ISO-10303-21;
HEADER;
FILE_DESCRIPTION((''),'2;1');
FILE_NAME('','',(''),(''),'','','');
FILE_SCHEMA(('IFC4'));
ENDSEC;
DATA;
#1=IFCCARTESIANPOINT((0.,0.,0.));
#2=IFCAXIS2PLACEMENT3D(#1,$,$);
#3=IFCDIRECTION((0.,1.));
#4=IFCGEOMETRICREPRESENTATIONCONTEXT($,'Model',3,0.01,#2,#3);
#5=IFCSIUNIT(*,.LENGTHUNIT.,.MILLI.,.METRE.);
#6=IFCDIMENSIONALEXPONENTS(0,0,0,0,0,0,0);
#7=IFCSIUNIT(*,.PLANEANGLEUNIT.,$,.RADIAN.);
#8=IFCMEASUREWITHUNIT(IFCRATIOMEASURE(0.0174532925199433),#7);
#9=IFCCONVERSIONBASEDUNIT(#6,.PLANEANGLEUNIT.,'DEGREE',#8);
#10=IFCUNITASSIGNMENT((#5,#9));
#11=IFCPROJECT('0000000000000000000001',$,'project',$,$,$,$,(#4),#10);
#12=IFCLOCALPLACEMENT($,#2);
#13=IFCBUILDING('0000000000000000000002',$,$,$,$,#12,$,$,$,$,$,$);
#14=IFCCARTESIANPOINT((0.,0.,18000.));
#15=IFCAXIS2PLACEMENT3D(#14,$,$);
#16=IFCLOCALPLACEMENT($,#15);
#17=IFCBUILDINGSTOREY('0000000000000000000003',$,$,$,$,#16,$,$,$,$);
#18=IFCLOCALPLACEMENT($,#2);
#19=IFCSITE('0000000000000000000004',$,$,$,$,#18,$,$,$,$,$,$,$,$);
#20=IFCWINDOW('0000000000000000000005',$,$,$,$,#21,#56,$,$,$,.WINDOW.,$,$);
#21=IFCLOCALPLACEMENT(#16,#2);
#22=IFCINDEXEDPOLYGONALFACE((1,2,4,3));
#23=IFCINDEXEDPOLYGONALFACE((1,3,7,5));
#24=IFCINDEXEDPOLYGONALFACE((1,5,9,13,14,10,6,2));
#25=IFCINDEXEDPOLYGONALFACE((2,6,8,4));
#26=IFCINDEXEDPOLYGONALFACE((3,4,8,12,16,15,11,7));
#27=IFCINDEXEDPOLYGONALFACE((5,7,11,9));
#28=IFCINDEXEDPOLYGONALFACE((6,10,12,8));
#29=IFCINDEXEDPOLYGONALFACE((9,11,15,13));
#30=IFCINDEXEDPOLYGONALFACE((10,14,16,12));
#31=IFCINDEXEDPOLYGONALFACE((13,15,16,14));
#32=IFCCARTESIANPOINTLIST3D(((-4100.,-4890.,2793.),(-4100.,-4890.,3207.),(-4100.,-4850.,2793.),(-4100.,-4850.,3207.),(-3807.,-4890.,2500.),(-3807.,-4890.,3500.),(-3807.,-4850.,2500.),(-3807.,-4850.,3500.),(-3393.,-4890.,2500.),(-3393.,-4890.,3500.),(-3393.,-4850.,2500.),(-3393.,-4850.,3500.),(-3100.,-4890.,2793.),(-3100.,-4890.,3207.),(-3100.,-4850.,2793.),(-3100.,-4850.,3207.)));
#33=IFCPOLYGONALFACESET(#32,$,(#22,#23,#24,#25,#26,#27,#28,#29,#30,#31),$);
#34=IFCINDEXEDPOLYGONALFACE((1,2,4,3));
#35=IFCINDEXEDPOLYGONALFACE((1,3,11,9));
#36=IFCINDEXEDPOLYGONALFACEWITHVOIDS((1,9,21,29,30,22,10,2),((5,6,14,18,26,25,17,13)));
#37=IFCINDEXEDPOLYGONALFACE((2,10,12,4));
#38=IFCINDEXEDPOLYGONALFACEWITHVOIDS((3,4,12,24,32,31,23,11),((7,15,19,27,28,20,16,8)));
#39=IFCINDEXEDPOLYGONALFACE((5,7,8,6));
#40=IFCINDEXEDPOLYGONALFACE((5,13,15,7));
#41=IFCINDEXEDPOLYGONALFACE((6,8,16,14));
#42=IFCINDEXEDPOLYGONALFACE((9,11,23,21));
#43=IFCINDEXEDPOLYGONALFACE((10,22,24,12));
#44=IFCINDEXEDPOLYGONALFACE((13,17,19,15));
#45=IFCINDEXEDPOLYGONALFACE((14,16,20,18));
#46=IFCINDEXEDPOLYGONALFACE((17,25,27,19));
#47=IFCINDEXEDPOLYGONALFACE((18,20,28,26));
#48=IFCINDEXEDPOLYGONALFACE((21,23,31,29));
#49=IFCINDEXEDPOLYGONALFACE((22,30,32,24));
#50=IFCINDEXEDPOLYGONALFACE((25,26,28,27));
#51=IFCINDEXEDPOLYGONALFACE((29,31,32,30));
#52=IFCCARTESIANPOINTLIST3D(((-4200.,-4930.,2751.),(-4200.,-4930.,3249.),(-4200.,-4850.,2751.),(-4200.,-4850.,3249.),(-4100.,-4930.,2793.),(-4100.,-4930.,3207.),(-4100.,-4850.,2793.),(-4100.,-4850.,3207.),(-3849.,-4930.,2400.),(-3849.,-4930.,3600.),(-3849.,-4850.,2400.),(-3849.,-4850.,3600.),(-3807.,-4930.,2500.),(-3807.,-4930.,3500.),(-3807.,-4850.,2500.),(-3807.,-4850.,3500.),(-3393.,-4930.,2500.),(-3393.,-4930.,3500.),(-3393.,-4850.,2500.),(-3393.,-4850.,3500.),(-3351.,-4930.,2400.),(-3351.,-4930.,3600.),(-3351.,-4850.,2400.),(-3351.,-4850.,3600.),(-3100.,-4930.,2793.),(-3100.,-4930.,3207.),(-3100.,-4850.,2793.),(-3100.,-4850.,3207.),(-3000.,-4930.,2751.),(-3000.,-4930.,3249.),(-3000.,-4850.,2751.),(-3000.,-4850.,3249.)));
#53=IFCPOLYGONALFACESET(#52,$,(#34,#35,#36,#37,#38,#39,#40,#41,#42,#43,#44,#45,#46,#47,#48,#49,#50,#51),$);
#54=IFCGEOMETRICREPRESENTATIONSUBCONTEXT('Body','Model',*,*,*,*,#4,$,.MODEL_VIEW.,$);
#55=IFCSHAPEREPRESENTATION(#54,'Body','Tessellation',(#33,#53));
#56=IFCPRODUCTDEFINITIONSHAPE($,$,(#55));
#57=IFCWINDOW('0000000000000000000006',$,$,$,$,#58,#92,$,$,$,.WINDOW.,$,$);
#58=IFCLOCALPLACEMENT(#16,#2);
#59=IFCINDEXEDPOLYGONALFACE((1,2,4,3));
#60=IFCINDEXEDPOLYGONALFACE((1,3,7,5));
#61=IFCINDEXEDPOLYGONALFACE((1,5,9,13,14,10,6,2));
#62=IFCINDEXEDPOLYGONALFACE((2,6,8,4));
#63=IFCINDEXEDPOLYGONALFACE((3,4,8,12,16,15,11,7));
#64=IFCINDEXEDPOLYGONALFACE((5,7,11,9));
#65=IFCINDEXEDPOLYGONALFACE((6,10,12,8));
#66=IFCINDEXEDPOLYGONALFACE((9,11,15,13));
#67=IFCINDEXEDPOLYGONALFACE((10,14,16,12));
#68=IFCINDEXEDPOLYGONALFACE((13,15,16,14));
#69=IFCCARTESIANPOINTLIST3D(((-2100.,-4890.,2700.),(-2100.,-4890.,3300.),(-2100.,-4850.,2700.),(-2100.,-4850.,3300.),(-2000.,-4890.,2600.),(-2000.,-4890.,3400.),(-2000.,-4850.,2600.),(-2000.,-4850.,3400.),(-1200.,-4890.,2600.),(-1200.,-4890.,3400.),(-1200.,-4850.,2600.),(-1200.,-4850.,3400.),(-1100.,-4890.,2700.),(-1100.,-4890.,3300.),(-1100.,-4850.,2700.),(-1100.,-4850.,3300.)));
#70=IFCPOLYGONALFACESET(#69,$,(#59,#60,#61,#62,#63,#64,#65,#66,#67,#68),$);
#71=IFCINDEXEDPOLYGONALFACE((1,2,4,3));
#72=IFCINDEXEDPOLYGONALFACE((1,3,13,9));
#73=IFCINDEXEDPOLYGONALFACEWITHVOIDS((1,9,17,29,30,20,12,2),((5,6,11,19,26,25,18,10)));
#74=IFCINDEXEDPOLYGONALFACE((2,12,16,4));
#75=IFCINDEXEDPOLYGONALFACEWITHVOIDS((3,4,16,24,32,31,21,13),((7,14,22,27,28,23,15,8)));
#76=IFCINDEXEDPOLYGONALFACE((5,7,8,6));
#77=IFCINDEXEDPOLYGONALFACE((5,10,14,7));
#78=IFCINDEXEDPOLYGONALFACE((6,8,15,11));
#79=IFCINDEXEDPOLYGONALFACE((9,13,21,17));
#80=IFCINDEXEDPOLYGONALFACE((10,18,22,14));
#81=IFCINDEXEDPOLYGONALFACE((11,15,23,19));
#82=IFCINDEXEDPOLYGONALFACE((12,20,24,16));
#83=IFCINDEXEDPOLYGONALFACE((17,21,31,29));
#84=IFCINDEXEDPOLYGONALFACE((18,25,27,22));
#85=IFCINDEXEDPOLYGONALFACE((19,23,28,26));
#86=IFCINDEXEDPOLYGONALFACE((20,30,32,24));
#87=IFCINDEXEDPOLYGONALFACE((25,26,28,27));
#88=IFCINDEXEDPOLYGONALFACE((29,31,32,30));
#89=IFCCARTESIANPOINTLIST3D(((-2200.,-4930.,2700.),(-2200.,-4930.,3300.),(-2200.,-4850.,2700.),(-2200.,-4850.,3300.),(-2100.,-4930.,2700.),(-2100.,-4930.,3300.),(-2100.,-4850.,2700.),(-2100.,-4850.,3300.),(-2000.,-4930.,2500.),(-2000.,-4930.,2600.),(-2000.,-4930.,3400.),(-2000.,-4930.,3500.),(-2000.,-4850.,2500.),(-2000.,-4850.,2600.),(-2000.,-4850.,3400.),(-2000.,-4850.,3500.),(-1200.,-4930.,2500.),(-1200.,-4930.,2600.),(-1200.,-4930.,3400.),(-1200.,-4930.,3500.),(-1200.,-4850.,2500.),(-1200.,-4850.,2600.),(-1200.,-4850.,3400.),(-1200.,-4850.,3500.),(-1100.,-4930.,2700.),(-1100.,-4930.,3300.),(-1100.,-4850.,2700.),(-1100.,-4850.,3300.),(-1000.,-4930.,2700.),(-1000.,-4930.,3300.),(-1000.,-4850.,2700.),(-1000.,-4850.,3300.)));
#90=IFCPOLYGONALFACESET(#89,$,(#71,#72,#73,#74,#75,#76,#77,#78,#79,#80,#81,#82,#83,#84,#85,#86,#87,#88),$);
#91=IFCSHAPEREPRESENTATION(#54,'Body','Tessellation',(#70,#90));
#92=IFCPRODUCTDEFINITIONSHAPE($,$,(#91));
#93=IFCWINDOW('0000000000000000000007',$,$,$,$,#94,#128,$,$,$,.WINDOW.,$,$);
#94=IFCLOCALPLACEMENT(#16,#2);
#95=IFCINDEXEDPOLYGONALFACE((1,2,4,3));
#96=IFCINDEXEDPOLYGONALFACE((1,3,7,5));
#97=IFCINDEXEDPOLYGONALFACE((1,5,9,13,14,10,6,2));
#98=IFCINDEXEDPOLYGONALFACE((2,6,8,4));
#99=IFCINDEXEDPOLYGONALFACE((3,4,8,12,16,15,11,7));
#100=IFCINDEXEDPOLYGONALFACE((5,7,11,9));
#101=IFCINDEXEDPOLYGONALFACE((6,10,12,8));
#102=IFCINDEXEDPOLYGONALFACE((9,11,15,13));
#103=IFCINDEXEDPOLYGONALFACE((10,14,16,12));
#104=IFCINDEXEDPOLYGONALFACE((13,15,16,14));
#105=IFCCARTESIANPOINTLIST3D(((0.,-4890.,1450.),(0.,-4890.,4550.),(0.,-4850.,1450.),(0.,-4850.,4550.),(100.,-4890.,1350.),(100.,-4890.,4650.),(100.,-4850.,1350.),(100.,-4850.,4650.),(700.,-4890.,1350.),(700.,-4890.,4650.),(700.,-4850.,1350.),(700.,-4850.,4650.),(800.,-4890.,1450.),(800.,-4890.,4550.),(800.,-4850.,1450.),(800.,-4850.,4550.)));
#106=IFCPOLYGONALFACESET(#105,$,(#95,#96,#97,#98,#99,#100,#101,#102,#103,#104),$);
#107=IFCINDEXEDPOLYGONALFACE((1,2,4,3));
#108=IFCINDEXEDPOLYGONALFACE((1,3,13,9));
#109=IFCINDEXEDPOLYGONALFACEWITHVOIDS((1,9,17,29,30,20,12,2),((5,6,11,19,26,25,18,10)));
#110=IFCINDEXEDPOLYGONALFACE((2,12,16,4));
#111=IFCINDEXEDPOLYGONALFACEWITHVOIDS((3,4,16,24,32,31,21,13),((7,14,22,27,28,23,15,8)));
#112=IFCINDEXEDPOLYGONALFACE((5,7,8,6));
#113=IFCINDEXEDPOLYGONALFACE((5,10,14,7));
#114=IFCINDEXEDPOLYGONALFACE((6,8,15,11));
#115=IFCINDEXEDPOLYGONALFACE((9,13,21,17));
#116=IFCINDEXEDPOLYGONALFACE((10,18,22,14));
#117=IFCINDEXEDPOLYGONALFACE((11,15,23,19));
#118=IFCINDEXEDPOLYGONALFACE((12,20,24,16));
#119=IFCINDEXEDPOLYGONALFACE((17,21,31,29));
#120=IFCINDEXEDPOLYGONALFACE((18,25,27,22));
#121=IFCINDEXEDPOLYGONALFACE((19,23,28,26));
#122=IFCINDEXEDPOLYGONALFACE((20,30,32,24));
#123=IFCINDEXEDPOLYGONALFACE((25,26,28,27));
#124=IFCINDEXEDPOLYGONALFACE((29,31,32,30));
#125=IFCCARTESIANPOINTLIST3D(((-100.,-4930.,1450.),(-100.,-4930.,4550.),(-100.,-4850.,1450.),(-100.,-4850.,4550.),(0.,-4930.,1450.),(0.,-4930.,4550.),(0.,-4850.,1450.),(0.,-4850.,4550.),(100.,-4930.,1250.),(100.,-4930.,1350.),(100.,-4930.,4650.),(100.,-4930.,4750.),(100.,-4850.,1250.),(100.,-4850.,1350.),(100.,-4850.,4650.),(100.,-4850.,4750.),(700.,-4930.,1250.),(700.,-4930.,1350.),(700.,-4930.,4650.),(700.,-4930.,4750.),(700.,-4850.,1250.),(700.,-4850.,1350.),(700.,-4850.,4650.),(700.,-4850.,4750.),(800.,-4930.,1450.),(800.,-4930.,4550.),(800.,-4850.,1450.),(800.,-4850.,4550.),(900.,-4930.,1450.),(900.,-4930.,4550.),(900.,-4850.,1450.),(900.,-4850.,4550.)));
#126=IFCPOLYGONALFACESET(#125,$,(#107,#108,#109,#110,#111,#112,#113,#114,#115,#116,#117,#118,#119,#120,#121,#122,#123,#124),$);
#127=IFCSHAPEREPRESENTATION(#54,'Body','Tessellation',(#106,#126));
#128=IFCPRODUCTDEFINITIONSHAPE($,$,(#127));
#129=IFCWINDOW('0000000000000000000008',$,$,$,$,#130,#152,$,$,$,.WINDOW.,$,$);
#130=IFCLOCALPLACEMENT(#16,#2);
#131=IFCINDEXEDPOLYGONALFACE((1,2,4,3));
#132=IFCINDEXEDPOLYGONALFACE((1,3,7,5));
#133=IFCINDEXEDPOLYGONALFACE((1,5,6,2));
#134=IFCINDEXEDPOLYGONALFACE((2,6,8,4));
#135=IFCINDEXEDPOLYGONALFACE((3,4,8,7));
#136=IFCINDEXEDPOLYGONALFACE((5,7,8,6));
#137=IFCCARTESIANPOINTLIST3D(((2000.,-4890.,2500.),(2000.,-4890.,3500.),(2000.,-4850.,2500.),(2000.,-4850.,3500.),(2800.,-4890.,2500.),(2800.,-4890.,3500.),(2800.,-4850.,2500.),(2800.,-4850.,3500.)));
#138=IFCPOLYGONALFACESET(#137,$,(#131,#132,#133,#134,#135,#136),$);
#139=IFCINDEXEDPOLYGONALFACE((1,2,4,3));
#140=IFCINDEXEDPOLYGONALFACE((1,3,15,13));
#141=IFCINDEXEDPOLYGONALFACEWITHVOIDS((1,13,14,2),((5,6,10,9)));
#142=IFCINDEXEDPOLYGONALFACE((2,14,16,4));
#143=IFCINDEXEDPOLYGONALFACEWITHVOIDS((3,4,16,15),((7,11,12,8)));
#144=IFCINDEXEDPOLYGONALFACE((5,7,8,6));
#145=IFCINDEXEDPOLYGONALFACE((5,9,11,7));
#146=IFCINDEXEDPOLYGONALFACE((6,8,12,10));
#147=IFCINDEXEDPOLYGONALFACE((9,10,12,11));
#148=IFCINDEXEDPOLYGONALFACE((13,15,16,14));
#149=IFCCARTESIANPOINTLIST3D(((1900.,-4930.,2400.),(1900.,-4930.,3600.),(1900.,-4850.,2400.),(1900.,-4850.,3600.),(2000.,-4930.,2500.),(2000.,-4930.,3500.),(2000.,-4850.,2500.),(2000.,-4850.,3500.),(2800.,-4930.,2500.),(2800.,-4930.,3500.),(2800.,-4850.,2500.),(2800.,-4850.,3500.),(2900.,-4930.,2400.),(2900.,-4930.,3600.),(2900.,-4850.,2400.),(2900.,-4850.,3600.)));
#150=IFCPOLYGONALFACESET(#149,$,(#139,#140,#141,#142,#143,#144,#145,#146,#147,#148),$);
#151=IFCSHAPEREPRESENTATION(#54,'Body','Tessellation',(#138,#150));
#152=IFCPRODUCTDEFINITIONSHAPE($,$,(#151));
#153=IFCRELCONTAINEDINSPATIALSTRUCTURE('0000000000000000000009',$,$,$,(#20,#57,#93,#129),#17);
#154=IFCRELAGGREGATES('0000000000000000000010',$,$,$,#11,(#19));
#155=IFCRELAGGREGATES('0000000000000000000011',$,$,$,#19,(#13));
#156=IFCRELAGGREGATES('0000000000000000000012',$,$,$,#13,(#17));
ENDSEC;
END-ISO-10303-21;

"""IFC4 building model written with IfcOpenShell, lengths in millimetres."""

from ifc_helpers import new_model, entity, si_unit, converted_unit, direction, frame, origin, place, context, subcontext, project, spatial, element, save


model = new_model("IFC4")

# Units and contexts
model_context = context("Model", 3, precision=0.01, world=origin(), true_north=direction((0.0, 1.0)))
body_context = subcontext(model_context, "Body", "Model", "MODEL_VIEW")
ifc_project = project(units=[si_unit("LENGTHUNIT", "METRE", prefix="MILLI"), converted_unit("PLANEANGLEUNIT", "DEGREE", entity("IfcRatioMeasure", 0.0174532925199433), si_unit("PLANEANGLEUNIT", "RADIAN"), dimensions=[0, 0, 0, 0, 0, 0, 0])], contexts=[model_context])

# Site, building, storey
site_placement = place(None, origin())
site = spatial("IfcSite", under=ifc_project, at=site_placement)
building_placement = place(None, origin())
building = spatial("IfcBuilding", under=site, at=building_placement)
storey_placement = place(None, frame((0.0, 0.0, 18000.0)))
storey = spatial("IfcBuildingStorey", under=building, at=storey_placement)

# Shared definitions
cartesian_point_1 = entity("IfcCartesianPoint", [-500.0, -207.0])
shared_polyline_1 = entity("IfcPolyline", [cartesian_point_1, entity("IfcCartesianPoint", [-500.0, 207.0]), entity("IfcCartesianPoint", [-207.0, 500.0]), entity("IfcCartesianPoint", [207.0, 500.0]), entity("IfcCartesianPoint", [500.0, 207.0]), entity("IfcCartesianPoint", [500.0, -207.0]), entity("IfcCartesianPoint", [207.0, -500.0]), entity("IfcCartesianPoint", [-207.0, -500.0]), cartesian_point_1])
cartesian_point_2 = entity("IfcCartesianPoint", [-500.0, -300.0])
shared_polyline_2 = entity("IfcPolyline", [cartesian_point_2, entity("IfcCartesianPoint", [-500.0, 300.0]), entity("IfcCartesianPoint", [-400.0, 400.0]), entity("IfcCartesianPoint", [400.0, 400.0]), entity("IfcCartesianPoint", [500.0, 300.0]), entity("IfcCartesianPoint", [500.0, -300.0]), entity("IfcCartesianPoint", [400.0, -400.0]), entity("IfcCartesianPoint", [-400.0, -400.0]), cartesian_point_2])
cartesian_point_3 = entity("IfcCartesianPoint", [-400.0, -1550.0])
shared_polyline_3 = entity("IfcPolyline", [cartesian_point_3, entity("IfcCartesianPoint", [-400.0, 1550.0]), entity("IfcCartesianPoint", [-300.0, 1650.0]), entity("IfcCartesianPoint", [300.0, 1650.0]), entity("IfcCartesianPoint", [400.0, 1550.0]), entity("IfcCartesianPoint", [400.0, -1550.0]), entity("IfcCartesianPoint", [300.0, -1650.0]), entity("IfcCartesianPoint", [-300.0, -1650.0]), cartesian_point_3])
cartesian_point_4 = entity("IfcCartesianPoint", [-400.0, -500.0])
shared_polyline_4 = entity("IfcPolyline", [cartesian_point_4, entity("IfcCartesianPoint", [-400.0, 500.0]), entity("IfcCartesianPoint", [-400.0, 500.0]), entity("IfcCartesianPoint", [400.0, 500.0]), entity("IfcCartesianPoint", [400.0, 500.0]), entity("IfcCartesianPoint", [400.0, -500.0]), entity("IfcCartesianPoint", [400.0, -500.0]), entity("IfcCartesianPoint", [-400.0, -500.0]), cartesian_point_4])

# Shared definitions
wall_1_placement = place(storey_placement, frame((-100.0, -4900.0, 0.0), z_axis=(0.0, 0.0, 1.0), x_axis=(1.0, 0.0, 0.0)))
window_1_placement = place(wall_1_placement, frame((-3500.0, 50.0, 3000.0)))
window_2_placement = place(wall_1_placement, frame((-1500.0, 50.0, 3000.0)))
window_3_placement = place(wall_1_placement, frame((500.0, 50.0, 3000.0)))
window_4_placement = place(wall_1_placement, frame((2500.0, 50.0, 3000.0)))

# Windows
cartesian_point_5 = entity("IfcCartesianPoint", [-600.0, -249.0])
element("IfcWindow", 1, at=window_1_placement, inside=storey, PredefinedType="WINDOW", context=body_context, shape_type="SweptSolid", body=[
    entity("IfcExtrudedAreaSolid", entity("IfcArbitraryClosedProfileDef", "AREA", None, shared_polyline_1), entity("IfcAxis2Placement3D", entity("IfcCartesianPoint", [0.0, 0.0, 0.0]), entity("IfcDirection", [0.0, -1.0, 0.0]), entity("IfcDirection", [1.0, 0.0, 0.0])), entity("IfcDirection", [0.0, 0.0, 1.0]), 40.0),
    entity("IfcExtrudedAreaSolid", entity("IfcArbitraryProfileDefWithVoids", "AREA", None, entity("IfcPolyline", [cartesian_point_5, entity("IfcCartesianPoint", [-600.0, 249.0]), entity("IfcCartesianPoint", [-249.0, 600.0]), entity("IfcCartesianPoint", [249.0, 600.0]), entity("IfcCartesianPoint", [600.0, 249.0]), entity("IfcCartesianPoint", [600.0, -249.0]), entity("IfcCartesianPoint", [249.0, -600.0]), entity("IfcCartesianPoint", [-249.0, -600.0]), cartesian_point_5]), [shared_polyline_1]), entity("IfcAxis2Placement3D", entity("IfcCartesianPoint", [0.0, 0.0, 0.0]), entity("IfcDirection", [0.0, -1.0, 0.0]), entity("IfcDirection", [1.0, 0.0, 0.0])), entity("IfcDirection", [0.0, 0.0, 1.0]), 80.0),
])
cartesian_point_6 = entity("IfcCartesianPoint", [-600.0, -300.0])
element("IfcWindow", 2, at=window_2_placement, inside=storey, PredefinedType="WINDOW", context=body_context, shape_type="SweptSolid", body=[
    entity("IfcExtrudedAreaSolid", entity("IfcArbitraryClosedProfileDef", "AREA", None, shared_polyline_2), entity("IfcAxis2Placement3D", entity("IfcCartesianPoint", [0.0, 0.0, 0.0]), entity("IfcDirection", [0.0, -1.0, 0.0]), entity("IfcDirection", [1.0, 0.0, 0.0])), entity("IfcDirection", [0.0, 0.0, 1.0]), 40.0),
    entity("IfcExtrudedAreaSolid", entity("IfcArbitraryProfileDefWithVoids", "AREA", None, entity("IfcPolyline", [cartesian_point_6, entity("IfcCartesianPoint", [-600.0, 300.0]), entity("IfcCartesianPoint", [-400.0, 500.0]), entity("IfcCartesianPoint", [400.0, 500.0]), entity("IfcCartesianPoint", [600.0, 300.0]), entity("IfcCartesianPoint", [600.0, -300.0]), entity("IfcCartesianPoint", [400.0, -500.0]), entity("IfcCartesianPoint", [-400.0, -500.0]), cartesian_point_6]), [shared_polyline_2]), entity("IfcAxis2Placement3D", entity("IfcCartesianPoint", [0.0, 0.0, 0.0]), entity("IfcDirection", [0.0, -1.0, 0.0]), entity("IfcDirection", [1.0, 0.0, 0.0])), entity("IfcDirection", [0.0, 0.0, 1.0]), 80.0),
])
cartesian_point_7 = entity("IfcCartesianPoint", [-500.0, -1550.0])
element("IfcWindow", 3, at=window_3_placement, inside=storey, PredefinedType="WINDOW", context=body_context, shape_type="SweptSolid", body=[
    entity("IfcExtrudedAreaSolid", entity("IfcArbitraryClosedProfileDef", "AREA", None, shared_polyline_3), entity("IfcAxis2Placement3D", entity("IfcCartesianPoint", [0.0, 0.0, 0.0]), entity("IfcDirection", [0.0, -1.0, 0.0]), entity("IfcDirection", [1.0, 0.0, 0.0])), entity("IfcDirection", [0.0, 0.0, 1.0]), 40.0),
    entity("IfcExtrudedAreaSolid", entity("IfcArbitraryProfileDefWithVoids", "AREA", None, entity("IfcPolyline", [cartesian_point_7, entity("IfcCartesianPoint", [-500.0, 1550.0]), entity("IfcCartesianPoint", [-300.0, 1750.0]), entity("IfcCartesianPoint", [300.0, 1750.0]), entity("IfcCartesianPoint", [500.0, 1550.0]), entity("IfcCartesianPoint", [500.0, -1550.0]), entity("IfcCartesianPoint", [300.0, -1750.0]), entity("IfcCartesianPoint", [-300.0, -1750.0]), cartesian_point_7]), [shared_polyline_3]), entity("IfcAxis2Placement3D", entity("IfcCartesianPoint", [0.0, 0.0, 0.0]), entity("IfcDirection", [0.0, -1.0, 0.0]), entity("IfcDirection", [1.0, 0.0, 0.0])), entity("IfcDirection", [0.0, 0.0, 1.0]), 80.0),
])
cartesian_point_8 = entity("IfcCartesianPoint", [-500.0, -600.0])
element("IfcWindow", 4, at=window_4_placement, inside=storey, PredefinedType="WINDOW", context=body_context, shape_type="SweptSolid", body=[
    entity("IfcExtrudedAreaSolid", entity("IfcArbitraryClosedProfileDef", "AREA", None, shared_polyline_4), entity("IfcAxis2Placement3D", entity("IfcCartesianPoint", [0.0, 0.0, 0.0]), entity("IfcDirection", [0.0, -1.0, 0.0]), entity("IfcDirection", [1.0, 0.0, 0.0])), entity("IfcDirection", [0.0, 0.0, 1.0]), 40.0),
    entity("IfcExtrudedAreaSolid", entity("IfcArbitraryProfileDefWithVoids", "AREA", None, entity("IfcPolyline", [cartesian_point_8, entity("IfcCartesianPoint", [-500.0, 600.0]), entity("IfcCartesianPoint", [-500.0, 600.0]), entity("IfcCartesianPoint", [500.0, 600.0]), entity("IfcCartesianPoint", [500.0, 600.0]), entity("IfcCartesianPoint", [500.0, -600.0]), entity("IfcCartesianPoint", [500.0, -600.0]), entity("IfcCartesianPoint", [-500.0, -600.0]), cartesian_point_8]), [shared_polyline_4]), entity("IfcAxis2Placement3D", entity("IfcCartesianPoint", [0.0, 0.0, 0.0]), entity("IfcDirection", [0.0, -1.0, 0.0]), entity("IfcDirection", [1.0, 0.0, 0.0])), entity("IfcDirection", [0.0, 0.0, 1.0]), 80.0),
])

save(model, "model.ifc")
